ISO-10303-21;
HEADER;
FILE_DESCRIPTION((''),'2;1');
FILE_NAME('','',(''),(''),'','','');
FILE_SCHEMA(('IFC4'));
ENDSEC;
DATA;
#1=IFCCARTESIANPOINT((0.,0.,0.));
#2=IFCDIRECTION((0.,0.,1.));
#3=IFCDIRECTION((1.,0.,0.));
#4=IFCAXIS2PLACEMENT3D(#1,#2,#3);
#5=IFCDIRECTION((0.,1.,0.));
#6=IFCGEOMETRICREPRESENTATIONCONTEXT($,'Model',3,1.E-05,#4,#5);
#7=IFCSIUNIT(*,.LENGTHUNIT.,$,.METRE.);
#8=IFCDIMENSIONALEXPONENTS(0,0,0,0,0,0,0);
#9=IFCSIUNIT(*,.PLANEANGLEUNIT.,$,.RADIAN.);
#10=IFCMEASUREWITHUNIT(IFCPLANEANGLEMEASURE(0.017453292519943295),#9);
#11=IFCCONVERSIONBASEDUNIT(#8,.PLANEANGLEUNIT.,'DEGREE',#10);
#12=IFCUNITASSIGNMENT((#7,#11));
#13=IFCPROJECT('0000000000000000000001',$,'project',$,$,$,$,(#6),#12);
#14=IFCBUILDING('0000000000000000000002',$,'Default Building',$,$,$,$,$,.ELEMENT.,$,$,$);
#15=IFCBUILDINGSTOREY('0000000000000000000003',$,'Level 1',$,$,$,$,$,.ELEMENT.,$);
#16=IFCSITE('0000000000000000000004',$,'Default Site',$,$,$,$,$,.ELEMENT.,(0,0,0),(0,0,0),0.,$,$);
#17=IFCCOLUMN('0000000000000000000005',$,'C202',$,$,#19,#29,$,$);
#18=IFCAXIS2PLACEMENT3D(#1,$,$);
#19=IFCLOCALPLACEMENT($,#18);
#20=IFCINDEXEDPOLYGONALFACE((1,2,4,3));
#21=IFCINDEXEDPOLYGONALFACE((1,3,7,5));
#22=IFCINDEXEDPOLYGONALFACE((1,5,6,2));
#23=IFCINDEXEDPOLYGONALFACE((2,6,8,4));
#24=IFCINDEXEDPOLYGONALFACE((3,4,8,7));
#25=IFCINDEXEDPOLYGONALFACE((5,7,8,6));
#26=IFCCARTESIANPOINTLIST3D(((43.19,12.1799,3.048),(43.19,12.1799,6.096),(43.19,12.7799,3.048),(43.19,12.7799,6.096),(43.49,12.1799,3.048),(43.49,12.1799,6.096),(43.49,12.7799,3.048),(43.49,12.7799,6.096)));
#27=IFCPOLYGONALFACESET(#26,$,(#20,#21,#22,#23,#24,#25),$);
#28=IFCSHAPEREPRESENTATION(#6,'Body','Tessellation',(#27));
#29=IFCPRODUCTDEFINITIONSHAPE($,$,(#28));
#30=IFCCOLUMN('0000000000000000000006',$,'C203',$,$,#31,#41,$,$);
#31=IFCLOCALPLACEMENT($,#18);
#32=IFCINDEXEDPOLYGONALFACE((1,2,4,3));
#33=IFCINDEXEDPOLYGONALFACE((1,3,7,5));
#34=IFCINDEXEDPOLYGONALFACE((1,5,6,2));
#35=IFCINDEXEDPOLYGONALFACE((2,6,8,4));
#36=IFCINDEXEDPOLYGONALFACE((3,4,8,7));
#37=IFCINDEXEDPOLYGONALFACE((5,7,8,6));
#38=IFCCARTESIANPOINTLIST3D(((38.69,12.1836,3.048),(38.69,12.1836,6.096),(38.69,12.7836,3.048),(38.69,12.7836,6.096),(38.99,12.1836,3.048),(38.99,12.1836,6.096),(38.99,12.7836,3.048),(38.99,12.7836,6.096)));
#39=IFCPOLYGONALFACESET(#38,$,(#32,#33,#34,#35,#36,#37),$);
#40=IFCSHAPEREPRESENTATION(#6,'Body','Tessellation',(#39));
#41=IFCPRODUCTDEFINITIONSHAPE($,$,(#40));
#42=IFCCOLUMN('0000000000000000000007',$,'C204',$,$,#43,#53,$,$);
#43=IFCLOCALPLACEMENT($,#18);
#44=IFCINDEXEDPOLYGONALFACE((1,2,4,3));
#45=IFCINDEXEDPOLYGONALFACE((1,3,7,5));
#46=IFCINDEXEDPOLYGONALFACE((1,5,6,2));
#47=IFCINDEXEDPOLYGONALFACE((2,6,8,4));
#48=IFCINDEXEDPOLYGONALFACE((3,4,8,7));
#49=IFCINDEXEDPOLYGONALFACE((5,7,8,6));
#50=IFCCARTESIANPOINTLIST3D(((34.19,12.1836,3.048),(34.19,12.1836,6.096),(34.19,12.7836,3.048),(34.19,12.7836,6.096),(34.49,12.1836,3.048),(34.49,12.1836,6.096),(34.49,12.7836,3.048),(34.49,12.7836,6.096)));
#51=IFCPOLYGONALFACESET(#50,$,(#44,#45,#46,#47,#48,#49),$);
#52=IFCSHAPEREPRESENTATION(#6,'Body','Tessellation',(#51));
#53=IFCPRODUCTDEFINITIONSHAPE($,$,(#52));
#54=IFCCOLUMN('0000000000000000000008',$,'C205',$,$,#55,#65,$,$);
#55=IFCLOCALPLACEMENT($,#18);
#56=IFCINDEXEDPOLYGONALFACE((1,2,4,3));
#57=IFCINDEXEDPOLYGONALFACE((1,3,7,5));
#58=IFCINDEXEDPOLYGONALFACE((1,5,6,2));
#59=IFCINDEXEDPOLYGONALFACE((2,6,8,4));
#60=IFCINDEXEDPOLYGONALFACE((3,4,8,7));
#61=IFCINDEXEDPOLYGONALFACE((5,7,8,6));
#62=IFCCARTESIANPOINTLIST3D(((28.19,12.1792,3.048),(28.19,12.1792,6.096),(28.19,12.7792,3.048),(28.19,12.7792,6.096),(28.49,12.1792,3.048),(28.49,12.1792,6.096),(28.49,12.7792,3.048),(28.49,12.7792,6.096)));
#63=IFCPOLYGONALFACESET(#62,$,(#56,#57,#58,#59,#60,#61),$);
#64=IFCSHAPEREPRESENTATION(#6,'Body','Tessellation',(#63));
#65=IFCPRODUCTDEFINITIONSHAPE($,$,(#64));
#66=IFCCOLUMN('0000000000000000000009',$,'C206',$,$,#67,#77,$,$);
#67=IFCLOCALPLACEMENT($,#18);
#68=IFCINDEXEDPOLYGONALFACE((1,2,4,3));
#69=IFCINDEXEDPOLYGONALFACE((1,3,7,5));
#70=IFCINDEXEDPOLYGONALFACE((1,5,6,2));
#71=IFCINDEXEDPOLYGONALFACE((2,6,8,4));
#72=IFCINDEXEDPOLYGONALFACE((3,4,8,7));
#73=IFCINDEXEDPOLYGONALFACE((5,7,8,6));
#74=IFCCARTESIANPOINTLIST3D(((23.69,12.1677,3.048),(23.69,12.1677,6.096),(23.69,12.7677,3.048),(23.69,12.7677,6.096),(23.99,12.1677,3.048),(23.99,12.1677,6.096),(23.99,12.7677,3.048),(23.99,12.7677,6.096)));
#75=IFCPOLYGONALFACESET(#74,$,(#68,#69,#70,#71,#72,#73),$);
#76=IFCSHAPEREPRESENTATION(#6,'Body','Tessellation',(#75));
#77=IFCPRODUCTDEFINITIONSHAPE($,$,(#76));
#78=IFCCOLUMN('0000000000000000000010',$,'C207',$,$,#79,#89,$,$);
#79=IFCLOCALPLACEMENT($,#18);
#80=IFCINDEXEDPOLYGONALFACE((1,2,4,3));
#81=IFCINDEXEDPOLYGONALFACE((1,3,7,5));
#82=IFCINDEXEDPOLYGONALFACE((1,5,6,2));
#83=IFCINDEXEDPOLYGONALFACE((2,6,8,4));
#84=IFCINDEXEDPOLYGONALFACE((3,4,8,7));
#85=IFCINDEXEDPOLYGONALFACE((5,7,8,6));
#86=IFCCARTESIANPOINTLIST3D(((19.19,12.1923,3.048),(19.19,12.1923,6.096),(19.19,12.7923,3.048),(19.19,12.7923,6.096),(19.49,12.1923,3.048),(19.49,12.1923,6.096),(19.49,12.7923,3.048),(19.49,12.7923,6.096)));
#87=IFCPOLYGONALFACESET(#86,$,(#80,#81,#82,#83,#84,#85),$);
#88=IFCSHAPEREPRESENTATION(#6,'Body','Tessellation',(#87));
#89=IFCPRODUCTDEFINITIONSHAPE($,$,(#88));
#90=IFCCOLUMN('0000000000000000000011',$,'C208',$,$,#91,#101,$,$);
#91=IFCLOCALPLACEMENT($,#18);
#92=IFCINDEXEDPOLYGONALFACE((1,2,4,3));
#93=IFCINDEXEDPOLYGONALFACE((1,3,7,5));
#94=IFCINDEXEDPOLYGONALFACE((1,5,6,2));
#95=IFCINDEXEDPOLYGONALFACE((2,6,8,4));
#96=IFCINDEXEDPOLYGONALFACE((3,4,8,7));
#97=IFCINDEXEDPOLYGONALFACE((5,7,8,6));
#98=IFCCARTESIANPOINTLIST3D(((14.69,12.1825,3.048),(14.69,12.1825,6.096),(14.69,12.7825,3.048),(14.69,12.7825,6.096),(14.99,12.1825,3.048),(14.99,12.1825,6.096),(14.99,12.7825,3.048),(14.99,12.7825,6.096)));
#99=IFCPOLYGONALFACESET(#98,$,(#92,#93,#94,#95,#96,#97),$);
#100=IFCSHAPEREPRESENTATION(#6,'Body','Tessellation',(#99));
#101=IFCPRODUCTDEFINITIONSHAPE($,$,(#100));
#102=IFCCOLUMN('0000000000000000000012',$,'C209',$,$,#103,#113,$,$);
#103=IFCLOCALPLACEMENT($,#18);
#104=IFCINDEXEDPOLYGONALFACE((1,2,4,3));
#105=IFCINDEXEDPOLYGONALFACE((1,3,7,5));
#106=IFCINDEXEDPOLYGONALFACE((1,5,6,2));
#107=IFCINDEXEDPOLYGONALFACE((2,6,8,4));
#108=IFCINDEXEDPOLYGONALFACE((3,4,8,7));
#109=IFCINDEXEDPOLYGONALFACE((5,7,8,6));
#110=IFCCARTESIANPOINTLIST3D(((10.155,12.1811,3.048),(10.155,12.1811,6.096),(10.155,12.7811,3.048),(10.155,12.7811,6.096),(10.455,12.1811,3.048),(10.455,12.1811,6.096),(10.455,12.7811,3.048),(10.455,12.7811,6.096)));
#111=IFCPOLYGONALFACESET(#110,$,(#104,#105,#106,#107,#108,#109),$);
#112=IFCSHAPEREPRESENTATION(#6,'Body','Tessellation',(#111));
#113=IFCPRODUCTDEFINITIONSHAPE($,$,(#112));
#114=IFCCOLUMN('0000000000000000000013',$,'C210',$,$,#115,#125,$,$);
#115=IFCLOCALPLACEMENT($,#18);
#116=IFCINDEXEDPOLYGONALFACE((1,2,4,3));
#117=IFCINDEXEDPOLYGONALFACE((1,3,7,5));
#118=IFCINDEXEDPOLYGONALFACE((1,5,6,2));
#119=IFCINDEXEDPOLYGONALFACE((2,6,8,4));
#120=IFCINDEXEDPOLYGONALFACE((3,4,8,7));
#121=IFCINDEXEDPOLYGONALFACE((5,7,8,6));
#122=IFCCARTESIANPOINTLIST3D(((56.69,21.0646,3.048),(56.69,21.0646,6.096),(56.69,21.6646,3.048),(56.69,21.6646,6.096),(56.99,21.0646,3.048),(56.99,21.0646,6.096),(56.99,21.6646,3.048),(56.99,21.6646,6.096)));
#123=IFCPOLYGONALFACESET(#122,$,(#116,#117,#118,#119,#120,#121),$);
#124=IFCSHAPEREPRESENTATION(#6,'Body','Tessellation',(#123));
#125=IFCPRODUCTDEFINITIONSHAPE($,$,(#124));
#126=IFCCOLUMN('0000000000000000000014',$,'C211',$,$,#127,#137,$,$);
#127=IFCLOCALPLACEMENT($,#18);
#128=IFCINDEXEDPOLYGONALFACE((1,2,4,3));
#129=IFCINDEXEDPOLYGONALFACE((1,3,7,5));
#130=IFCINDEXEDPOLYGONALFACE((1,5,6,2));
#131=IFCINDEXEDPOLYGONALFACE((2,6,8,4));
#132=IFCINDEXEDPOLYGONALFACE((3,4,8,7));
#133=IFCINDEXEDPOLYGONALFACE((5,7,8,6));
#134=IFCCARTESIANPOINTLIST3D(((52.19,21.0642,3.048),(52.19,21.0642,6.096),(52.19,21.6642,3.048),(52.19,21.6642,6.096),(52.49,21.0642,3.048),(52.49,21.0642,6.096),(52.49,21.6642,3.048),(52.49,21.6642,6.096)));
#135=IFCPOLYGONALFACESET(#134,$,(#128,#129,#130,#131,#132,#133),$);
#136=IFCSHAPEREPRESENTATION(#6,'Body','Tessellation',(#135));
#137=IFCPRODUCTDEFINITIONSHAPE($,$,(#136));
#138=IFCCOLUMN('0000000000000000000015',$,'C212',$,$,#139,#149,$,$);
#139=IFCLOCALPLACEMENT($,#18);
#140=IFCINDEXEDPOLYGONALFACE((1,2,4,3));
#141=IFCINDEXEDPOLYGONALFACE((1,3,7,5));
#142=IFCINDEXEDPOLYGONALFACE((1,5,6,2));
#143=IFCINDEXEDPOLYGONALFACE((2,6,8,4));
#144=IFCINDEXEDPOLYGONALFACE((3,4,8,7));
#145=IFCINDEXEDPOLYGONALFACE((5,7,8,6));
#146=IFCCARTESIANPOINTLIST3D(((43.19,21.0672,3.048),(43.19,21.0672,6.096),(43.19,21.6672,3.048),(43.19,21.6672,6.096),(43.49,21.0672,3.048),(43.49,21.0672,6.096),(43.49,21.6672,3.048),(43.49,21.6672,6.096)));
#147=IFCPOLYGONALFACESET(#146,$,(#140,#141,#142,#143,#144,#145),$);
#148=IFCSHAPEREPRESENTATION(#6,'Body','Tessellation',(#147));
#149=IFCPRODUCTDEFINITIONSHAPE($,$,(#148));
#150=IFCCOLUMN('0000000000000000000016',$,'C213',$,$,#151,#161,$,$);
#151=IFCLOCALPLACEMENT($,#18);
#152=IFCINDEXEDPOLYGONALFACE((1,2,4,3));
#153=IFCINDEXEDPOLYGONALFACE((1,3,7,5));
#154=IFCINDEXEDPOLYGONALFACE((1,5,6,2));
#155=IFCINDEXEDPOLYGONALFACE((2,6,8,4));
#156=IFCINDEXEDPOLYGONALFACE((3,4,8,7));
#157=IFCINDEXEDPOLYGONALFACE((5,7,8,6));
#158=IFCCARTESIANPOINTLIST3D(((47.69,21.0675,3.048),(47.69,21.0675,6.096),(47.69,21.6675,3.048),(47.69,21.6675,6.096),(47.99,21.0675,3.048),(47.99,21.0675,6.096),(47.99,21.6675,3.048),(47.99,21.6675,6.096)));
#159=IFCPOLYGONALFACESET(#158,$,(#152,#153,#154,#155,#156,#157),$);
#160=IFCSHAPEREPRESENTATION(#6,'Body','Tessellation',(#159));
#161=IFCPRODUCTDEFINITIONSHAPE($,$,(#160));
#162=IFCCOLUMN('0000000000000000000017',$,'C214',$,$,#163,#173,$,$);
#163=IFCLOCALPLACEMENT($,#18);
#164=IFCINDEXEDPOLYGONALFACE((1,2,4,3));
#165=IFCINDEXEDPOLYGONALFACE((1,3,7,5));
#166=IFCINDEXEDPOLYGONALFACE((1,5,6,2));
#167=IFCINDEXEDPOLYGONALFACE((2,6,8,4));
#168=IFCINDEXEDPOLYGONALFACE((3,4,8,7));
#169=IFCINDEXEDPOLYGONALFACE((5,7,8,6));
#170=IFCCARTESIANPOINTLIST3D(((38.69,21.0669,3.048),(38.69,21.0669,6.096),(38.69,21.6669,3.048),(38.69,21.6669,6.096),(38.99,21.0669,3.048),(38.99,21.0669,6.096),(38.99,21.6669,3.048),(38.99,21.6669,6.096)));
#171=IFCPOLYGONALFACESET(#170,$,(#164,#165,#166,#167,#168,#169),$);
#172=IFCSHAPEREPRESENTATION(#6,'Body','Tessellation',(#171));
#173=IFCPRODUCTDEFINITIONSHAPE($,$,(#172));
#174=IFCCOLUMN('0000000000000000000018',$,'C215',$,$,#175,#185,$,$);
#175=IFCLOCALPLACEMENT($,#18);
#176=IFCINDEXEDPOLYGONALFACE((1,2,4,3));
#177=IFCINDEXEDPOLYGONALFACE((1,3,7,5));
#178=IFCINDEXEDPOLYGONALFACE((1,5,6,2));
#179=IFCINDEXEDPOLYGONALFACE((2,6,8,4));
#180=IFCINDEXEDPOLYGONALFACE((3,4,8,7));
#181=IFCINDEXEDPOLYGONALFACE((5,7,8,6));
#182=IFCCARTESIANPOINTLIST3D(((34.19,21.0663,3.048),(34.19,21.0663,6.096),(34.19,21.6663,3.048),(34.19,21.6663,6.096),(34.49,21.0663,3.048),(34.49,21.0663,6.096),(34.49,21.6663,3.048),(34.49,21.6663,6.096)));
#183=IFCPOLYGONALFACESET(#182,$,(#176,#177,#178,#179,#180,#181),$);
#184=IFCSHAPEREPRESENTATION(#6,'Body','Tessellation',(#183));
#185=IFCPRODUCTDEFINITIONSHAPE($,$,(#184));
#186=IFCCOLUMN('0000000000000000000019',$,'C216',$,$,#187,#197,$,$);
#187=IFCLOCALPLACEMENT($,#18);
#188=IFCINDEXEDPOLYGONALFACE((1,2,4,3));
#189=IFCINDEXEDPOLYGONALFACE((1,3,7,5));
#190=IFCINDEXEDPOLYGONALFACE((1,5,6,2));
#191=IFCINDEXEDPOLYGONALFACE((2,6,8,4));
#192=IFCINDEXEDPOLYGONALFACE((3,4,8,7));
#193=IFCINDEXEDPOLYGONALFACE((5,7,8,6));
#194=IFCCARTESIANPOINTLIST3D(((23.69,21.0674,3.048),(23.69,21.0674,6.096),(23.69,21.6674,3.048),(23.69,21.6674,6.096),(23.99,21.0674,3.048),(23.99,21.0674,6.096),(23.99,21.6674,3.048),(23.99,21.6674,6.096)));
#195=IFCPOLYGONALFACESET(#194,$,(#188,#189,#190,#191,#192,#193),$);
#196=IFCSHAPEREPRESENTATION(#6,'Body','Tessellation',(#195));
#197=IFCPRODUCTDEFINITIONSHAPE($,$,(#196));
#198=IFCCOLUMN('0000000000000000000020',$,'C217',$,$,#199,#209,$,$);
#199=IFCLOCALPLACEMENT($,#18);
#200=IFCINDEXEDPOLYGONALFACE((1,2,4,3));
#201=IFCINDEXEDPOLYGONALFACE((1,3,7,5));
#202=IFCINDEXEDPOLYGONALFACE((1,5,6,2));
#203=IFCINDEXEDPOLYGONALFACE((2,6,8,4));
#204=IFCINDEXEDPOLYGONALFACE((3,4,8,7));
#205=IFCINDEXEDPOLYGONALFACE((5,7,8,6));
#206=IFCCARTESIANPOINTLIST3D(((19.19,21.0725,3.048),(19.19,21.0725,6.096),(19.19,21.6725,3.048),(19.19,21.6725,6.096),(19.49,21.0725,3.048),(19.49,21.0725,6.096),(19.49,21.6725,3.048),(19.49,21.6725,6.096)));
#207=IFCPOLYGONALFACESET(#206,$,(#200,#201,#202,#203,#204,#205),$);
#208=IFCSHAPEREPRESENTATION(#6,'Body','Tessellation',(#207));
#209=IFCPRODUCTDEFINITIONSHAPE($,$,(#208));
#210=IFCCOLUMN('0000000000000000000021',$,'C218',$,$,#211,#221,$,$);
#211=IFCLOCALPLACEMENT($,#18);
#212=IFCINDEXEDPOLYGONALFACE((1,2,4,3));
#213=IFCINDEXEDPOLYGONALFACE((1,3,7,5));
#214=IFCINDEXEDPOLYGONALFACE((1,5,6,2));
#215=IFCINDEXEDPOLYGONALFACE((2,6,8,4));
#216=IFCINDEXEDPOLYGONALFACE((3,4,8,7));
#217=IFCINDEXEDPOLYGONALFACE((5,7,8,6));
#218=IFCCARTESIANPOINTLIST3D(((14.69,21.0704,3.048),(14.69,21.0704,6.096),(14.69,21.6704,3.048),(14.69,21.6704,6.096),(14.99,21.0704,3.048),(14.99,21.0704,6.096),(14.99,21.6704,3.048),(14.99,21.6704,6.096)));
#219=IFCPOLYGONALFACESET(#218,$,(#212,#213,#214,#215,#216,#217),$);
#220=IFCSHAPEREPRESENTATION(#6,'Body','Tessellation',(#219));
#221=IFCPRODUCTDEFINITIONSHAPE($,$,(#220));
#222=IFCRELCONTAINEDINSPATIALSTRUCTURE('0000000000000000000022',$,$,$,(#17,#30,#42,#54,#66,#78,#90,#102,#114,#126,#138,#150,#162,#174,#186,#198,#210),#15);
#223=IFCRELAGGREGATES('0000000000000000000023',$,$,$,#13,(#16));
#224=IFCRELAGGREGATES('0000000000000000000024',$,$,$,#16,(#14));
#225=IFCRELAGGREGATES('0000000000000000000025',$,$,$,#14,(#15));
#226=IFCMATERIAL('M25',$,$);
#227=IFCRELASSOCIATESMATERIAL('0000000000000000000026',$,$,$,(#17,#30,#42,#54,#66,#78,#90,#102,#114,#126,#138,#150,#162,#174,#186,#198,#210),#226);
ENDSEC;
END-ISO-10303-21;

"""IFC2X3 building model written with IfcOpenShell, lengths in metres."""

from ifc_helpers import new_model, entity, si_unit, converted_unit, direction, frame, frame_2d, origin_with_axes, place, context, project, spatial, rectangle, extrude, material, element, save


model = new_model("IFC2X3")

# Units and contexts
model_context = context("Model", 3, precision=1e-05, world=origin_with_axes(), true_north=direction((0.0, 1.0, 0.0)))
ifc_project = project(units=[si_unit("LENGTHUNIT", "METRE"), converted_unit("PLANEANGLEUNIT", "DEGREE", entity("IfcPlaneAngleMeasure", 0.017453292519943295), si_unit("PLANEANGLEUNIT", "RADIAN"), dimensions=[0, 0, 0, 0, 0, 0, 0])], contexts=[model_context])

# Site, building, storey
site = spatial("IfcSite", under=ifc_project, Name="Default Site", CompositionType="ELEMENT", RefLatitude=(0, 0, 0), RefLongitude=(0, 0, 0), RefElevation=0.0)
building = spatial("IfcBuilding", under=site, Name="Default Building", CompositionType="ELEMENT")
storey = spatial("IfcBuildingStorey", under=building, Name="Level 1", CompositionType="ELEMENT")

# Columns
ifc_material = material(Name="M25")
placement = place(None, origin_with_axes())
element("IfcColumn", 1, at=placement, inside=storey, material=ifc_material, Name="C202", context=model_context, shape_type="SweptSolid", body=[
    extrude(rectangle(XDim=0.3, YDim=0.6, at=frame_2d((0.0, 0.0), x_axis=(1.0, 0.0, 0.0))), frame((43.34, 12.4799, 3.048), z_axis=(0.0, 0.0, 1.0), x_axis=(1.0, 0.0, 0.0)), (0.0, 0.0, 1.0), 3.048),
])
element("IfcColumn", 2, at=placement, inside=storey, material=ifc_material, Name="C203", context=model_context, shape_type="SweptSolid", body=[
    extrude(rectangle(XDim=0.3, YDim=0.6, at=frame_2d((0.0, 0.0), x_axis=(1.0, 0.0, 0.0))), frame((38.84, 12.4836, 3.048), z_axis=(0.0, 0.0, 1.0), x_axis=(1.0, 0.0, 0.0)), (0.0, 0.0, 1.0), 3.048),
])
element("IfcColumn", 3, at=placement, inside=storey, material=ifc_material, Name="C204", context=model_context, shape_type="SweptSolid", body=[
    extrude(rectangle(XDim=0.3, YDim=0.6, at=frame_2d((0.0, 0.0), x_axis=(1.0, 0.0, 0.0))), frame((34.34, 12.4836, 3.048), z_axis=(0.0, 0.0, 1.0), x_axis=(1.0, 0.0, 0.0)), (0.0, 0.0, 1.0), 3.048),
])
element("IfcColumn", 4, at=placement, inside=storey, material=ifc_material, Name="C205", context=model_context, shape_type="SweptSolid", body=[
    extrude(rectangle(XDim=0.3, YDim=0.6, at=frame_2d((0.0, 0.0), x_axis=(1.0, 0.0, 0.0))), frame((28.34, 12.4792, 3.048), z_axis=(0.0, 0.0, 1.0), x_axis=(1.0, 0.0, 0.0)), (0.0, 0.0, 1.0), 3.048),
])
element("IfcColumn", 5, at=placement, inside=storey, material=ifc_material, Name="C206", context=model_context, shape_type="SweptSolid", body=[
    extrude(rectangle(XDim=0.3, YDim=0.6, at=frame_2d((0.0, 0.0), x_axis=(1.0, 0.0, 0.0))), frame((23.84, 12.4677, 3.048), z_axis=(0.0, 0.0, 1.0), x_axis=(1.0, 0.0, 0.0)), (0.0, 0.0, 1.0), 3.048),
])
element("IfcColumn", 6, at=placement, inside=storey, material=ifc_material, Name="C207", context=model_context, shape_type="SweptSolid", body=[
    extrude(rectangle(XDim=0.3, YDim=0.6, at=frame_2d((0.0, 0.0), x_axis=(1.0, 0.0, 0.0))), frame((19.34, 12.4923, 3.048), z_axis=(0.0, 0.0, 1.0), x_axis=(1.0, 0.0, 0.0)), (0.0, 0.0, 1.0), 3.048),
])
element("IfcColumn", 7, at=placement, inside=storey, material=ifc_material, Name="C208", context=model_context, shape_type="SweptSolid", body=[
    extrude(rectangle(XDim=0.3, YDim=0.6, at=frame_2d((0.0, 0.0), x_axis=(1.0, 0.0, 0.0))), frame((14.84, 12.4825, 3.048), z_axis=(0.0, 0.0, 1.0), x_axis=(1.0, 0.0, 0.0)), (0.0, 0.0, 1.0), 3.048),
])
element("IfcColumn", 8, at=placement, inside=storey, material=ifc_material, Name="C209", context=model_context, shape_type="SweptSolid", body=[
    extrude(rectangle(XDim=0.3, YDim=0.6, at=frame_2d((0.0, 0.0), x_axis=(1.0, 0.0, 0.0))), frame((10.305, 12.4811, 3.048), z_axis=(0.0, 0.0, 1.0), x_axis=(1.0, 0.0, 0.0)), (0.0, 0.0, 1.0), 3.048),
])
element("IfcColumn", 9, at=placement, inside=storey, material=ifc_material, Name="C210", context=model_context, shape_type="SweptSolid", body=[
    extrude(rectangle(XDim=0.3, YDim=0.6, at=frame_2d((0.0, 0.0), x_axis=(1.0, 0.0, 0.0))), frame((56.84, 21.3646, 3.048), z_axis=(0.0, 0.0, 1.0), x_axis=(1.0, 0.0, 0.0)), (0.0, 0.0, 1.0), 3.048),
])
element("IfcColumn", 10, at=placement, inside=storey, material=ifc_material, Name="C211", context=model_context, shape_type="SweptSolid", body=[
    extrude(rectangle(XDim=0.3, YDim=0.6, at=frame_2d((0.0, 0.0), x_axis=(1.0, 0.0, 0.0))), frame((52.34, 21.3642, 3.048), z_axis=(0.0, 0.0, 1.0), x_axis=(1.0, 0.0, 0.0)), (0.0, 0.0, 1.0), 3.048),
])
element("IfcColumn", 11, at=placement, inside=storey, material=ifc_material, Name="C212", context=model_context, shape_type="SweptSolid", body=[
    extrude(rectangle(XDim=0.3, YDim=0.6, at=frame_2d((0.0, 0.0), x_axis=(1.0, 0.0, 0.0))), frame((43.34, 21.3672, 3.048), z_axis=(0.0, 0.0, 1.0), x_axis=(1.0, 0.0, 0.0)), (0.0, 0.0, 1.0), 3.048),
])
element("IfcColumn", 12, at=placement, inside=storey, material=ifc_material, Name="C213", context=model_context, shape_type="SweptSolid", body=[
    extrude(rectangle(XDim=0.3, YDim=0.6, at=frame_2d((0.0, 0.0), x_axis=(1.0, 0.0, 0.0))), frame((47.84, 21.3675, 3.048), z_axis=(0.0, 0.0, 1.0), x_axis=(1.0, 0.0, 0.0)), (0.0, 0.0, 1.0), 3.048),
])
element("IfcColumn", 13, at=placement, inside=storey, material=ifc_material, Name="C214", context=model_context, shape_type="SweptSolid", body=[
    extrude(rectangle(XDim=0.3, YDim=0.6, at=frame_2d((0.0, 0.0), x_axis=(1.0, 0.0, 0.0))), frame((38.84, 21.3669, 3.048), z_axis=(0.0, 0.0, 1.0), x_axis=(1.0, 0.0, 0.0)), (0.0, 0.0, 1.0), 3.048),
])
element("IfcColumn", 14, at=placement, inside=storey, material=ifc_material, Name="C215", context=model_context, shape_type="SweptSolid", body=[
    extrude(rectangle(XDim=0.3, YDim=0.6, at=frame_2d((0.0, 0.0), x_axis=(1.0, 0.0, 0.0))), frame((34.34, 21.3663, 3.048), z_axis=(0.0, 0.0, 1.0), x_axis=(1.0, 0.0, 0.0)), (0.0, 0.0, 1.0), 3.048),
])
element("IfcColumn", 15, at=placement, inside=storey, material=ifc_material, Name="C216", context=model_context, shape_type="SweptSolid", body=[
    extrude(rectangle(XDim=0.3, YDim=0.6, at=frame_2d((0.0, 0.0), x_axis=(1.0, 0.0, 0.0))), frame((23.84, 21.3674, 3.048), z_axis=(0.0, 0.0, 1.0), x_axis=(1.0, 0.0, 0.0)), (0.0, 0.0, 1.0), 3.048),
])
element("IfcColumn", 16, at=placement, inside=storey, material=ifc_material, Name="C217", context=model_context, shape_type="SweptSolid", body=[
    extrude(rectangle(XDim=0.3, YDim=0.6, at=frame_2d((0.0, 0.0), x_axis=(1.0, 0.0, 0.0))), frame((19.34, 21.3725, 3.048), z_axis=(0.0, 0.0, 1.0), x_axis=(1.0, 0.0, 0.0)), (0.0, 0.0, 1.0), 3.048),
])
element("IfcColumn", 17, at=placement, inside=storey, material=ifc_material, Name="C218", context=model_context, shape_type="SweptSolid", body=[
    extrude(rectangle(XDim=0.3, YDim=0.6, at=frame_2d((0.0, 0.0), x_axis=(1.0, 0.0, 0.0))), frame((14.84, 21.3704, 3.048), z_axis=(0.0, 0.0, 1.0), x_axis=(1.0, 0.0, 0.0)), (0.0, 0.0, 1.0), 3.048),
])

save(model, "model.ifc")
